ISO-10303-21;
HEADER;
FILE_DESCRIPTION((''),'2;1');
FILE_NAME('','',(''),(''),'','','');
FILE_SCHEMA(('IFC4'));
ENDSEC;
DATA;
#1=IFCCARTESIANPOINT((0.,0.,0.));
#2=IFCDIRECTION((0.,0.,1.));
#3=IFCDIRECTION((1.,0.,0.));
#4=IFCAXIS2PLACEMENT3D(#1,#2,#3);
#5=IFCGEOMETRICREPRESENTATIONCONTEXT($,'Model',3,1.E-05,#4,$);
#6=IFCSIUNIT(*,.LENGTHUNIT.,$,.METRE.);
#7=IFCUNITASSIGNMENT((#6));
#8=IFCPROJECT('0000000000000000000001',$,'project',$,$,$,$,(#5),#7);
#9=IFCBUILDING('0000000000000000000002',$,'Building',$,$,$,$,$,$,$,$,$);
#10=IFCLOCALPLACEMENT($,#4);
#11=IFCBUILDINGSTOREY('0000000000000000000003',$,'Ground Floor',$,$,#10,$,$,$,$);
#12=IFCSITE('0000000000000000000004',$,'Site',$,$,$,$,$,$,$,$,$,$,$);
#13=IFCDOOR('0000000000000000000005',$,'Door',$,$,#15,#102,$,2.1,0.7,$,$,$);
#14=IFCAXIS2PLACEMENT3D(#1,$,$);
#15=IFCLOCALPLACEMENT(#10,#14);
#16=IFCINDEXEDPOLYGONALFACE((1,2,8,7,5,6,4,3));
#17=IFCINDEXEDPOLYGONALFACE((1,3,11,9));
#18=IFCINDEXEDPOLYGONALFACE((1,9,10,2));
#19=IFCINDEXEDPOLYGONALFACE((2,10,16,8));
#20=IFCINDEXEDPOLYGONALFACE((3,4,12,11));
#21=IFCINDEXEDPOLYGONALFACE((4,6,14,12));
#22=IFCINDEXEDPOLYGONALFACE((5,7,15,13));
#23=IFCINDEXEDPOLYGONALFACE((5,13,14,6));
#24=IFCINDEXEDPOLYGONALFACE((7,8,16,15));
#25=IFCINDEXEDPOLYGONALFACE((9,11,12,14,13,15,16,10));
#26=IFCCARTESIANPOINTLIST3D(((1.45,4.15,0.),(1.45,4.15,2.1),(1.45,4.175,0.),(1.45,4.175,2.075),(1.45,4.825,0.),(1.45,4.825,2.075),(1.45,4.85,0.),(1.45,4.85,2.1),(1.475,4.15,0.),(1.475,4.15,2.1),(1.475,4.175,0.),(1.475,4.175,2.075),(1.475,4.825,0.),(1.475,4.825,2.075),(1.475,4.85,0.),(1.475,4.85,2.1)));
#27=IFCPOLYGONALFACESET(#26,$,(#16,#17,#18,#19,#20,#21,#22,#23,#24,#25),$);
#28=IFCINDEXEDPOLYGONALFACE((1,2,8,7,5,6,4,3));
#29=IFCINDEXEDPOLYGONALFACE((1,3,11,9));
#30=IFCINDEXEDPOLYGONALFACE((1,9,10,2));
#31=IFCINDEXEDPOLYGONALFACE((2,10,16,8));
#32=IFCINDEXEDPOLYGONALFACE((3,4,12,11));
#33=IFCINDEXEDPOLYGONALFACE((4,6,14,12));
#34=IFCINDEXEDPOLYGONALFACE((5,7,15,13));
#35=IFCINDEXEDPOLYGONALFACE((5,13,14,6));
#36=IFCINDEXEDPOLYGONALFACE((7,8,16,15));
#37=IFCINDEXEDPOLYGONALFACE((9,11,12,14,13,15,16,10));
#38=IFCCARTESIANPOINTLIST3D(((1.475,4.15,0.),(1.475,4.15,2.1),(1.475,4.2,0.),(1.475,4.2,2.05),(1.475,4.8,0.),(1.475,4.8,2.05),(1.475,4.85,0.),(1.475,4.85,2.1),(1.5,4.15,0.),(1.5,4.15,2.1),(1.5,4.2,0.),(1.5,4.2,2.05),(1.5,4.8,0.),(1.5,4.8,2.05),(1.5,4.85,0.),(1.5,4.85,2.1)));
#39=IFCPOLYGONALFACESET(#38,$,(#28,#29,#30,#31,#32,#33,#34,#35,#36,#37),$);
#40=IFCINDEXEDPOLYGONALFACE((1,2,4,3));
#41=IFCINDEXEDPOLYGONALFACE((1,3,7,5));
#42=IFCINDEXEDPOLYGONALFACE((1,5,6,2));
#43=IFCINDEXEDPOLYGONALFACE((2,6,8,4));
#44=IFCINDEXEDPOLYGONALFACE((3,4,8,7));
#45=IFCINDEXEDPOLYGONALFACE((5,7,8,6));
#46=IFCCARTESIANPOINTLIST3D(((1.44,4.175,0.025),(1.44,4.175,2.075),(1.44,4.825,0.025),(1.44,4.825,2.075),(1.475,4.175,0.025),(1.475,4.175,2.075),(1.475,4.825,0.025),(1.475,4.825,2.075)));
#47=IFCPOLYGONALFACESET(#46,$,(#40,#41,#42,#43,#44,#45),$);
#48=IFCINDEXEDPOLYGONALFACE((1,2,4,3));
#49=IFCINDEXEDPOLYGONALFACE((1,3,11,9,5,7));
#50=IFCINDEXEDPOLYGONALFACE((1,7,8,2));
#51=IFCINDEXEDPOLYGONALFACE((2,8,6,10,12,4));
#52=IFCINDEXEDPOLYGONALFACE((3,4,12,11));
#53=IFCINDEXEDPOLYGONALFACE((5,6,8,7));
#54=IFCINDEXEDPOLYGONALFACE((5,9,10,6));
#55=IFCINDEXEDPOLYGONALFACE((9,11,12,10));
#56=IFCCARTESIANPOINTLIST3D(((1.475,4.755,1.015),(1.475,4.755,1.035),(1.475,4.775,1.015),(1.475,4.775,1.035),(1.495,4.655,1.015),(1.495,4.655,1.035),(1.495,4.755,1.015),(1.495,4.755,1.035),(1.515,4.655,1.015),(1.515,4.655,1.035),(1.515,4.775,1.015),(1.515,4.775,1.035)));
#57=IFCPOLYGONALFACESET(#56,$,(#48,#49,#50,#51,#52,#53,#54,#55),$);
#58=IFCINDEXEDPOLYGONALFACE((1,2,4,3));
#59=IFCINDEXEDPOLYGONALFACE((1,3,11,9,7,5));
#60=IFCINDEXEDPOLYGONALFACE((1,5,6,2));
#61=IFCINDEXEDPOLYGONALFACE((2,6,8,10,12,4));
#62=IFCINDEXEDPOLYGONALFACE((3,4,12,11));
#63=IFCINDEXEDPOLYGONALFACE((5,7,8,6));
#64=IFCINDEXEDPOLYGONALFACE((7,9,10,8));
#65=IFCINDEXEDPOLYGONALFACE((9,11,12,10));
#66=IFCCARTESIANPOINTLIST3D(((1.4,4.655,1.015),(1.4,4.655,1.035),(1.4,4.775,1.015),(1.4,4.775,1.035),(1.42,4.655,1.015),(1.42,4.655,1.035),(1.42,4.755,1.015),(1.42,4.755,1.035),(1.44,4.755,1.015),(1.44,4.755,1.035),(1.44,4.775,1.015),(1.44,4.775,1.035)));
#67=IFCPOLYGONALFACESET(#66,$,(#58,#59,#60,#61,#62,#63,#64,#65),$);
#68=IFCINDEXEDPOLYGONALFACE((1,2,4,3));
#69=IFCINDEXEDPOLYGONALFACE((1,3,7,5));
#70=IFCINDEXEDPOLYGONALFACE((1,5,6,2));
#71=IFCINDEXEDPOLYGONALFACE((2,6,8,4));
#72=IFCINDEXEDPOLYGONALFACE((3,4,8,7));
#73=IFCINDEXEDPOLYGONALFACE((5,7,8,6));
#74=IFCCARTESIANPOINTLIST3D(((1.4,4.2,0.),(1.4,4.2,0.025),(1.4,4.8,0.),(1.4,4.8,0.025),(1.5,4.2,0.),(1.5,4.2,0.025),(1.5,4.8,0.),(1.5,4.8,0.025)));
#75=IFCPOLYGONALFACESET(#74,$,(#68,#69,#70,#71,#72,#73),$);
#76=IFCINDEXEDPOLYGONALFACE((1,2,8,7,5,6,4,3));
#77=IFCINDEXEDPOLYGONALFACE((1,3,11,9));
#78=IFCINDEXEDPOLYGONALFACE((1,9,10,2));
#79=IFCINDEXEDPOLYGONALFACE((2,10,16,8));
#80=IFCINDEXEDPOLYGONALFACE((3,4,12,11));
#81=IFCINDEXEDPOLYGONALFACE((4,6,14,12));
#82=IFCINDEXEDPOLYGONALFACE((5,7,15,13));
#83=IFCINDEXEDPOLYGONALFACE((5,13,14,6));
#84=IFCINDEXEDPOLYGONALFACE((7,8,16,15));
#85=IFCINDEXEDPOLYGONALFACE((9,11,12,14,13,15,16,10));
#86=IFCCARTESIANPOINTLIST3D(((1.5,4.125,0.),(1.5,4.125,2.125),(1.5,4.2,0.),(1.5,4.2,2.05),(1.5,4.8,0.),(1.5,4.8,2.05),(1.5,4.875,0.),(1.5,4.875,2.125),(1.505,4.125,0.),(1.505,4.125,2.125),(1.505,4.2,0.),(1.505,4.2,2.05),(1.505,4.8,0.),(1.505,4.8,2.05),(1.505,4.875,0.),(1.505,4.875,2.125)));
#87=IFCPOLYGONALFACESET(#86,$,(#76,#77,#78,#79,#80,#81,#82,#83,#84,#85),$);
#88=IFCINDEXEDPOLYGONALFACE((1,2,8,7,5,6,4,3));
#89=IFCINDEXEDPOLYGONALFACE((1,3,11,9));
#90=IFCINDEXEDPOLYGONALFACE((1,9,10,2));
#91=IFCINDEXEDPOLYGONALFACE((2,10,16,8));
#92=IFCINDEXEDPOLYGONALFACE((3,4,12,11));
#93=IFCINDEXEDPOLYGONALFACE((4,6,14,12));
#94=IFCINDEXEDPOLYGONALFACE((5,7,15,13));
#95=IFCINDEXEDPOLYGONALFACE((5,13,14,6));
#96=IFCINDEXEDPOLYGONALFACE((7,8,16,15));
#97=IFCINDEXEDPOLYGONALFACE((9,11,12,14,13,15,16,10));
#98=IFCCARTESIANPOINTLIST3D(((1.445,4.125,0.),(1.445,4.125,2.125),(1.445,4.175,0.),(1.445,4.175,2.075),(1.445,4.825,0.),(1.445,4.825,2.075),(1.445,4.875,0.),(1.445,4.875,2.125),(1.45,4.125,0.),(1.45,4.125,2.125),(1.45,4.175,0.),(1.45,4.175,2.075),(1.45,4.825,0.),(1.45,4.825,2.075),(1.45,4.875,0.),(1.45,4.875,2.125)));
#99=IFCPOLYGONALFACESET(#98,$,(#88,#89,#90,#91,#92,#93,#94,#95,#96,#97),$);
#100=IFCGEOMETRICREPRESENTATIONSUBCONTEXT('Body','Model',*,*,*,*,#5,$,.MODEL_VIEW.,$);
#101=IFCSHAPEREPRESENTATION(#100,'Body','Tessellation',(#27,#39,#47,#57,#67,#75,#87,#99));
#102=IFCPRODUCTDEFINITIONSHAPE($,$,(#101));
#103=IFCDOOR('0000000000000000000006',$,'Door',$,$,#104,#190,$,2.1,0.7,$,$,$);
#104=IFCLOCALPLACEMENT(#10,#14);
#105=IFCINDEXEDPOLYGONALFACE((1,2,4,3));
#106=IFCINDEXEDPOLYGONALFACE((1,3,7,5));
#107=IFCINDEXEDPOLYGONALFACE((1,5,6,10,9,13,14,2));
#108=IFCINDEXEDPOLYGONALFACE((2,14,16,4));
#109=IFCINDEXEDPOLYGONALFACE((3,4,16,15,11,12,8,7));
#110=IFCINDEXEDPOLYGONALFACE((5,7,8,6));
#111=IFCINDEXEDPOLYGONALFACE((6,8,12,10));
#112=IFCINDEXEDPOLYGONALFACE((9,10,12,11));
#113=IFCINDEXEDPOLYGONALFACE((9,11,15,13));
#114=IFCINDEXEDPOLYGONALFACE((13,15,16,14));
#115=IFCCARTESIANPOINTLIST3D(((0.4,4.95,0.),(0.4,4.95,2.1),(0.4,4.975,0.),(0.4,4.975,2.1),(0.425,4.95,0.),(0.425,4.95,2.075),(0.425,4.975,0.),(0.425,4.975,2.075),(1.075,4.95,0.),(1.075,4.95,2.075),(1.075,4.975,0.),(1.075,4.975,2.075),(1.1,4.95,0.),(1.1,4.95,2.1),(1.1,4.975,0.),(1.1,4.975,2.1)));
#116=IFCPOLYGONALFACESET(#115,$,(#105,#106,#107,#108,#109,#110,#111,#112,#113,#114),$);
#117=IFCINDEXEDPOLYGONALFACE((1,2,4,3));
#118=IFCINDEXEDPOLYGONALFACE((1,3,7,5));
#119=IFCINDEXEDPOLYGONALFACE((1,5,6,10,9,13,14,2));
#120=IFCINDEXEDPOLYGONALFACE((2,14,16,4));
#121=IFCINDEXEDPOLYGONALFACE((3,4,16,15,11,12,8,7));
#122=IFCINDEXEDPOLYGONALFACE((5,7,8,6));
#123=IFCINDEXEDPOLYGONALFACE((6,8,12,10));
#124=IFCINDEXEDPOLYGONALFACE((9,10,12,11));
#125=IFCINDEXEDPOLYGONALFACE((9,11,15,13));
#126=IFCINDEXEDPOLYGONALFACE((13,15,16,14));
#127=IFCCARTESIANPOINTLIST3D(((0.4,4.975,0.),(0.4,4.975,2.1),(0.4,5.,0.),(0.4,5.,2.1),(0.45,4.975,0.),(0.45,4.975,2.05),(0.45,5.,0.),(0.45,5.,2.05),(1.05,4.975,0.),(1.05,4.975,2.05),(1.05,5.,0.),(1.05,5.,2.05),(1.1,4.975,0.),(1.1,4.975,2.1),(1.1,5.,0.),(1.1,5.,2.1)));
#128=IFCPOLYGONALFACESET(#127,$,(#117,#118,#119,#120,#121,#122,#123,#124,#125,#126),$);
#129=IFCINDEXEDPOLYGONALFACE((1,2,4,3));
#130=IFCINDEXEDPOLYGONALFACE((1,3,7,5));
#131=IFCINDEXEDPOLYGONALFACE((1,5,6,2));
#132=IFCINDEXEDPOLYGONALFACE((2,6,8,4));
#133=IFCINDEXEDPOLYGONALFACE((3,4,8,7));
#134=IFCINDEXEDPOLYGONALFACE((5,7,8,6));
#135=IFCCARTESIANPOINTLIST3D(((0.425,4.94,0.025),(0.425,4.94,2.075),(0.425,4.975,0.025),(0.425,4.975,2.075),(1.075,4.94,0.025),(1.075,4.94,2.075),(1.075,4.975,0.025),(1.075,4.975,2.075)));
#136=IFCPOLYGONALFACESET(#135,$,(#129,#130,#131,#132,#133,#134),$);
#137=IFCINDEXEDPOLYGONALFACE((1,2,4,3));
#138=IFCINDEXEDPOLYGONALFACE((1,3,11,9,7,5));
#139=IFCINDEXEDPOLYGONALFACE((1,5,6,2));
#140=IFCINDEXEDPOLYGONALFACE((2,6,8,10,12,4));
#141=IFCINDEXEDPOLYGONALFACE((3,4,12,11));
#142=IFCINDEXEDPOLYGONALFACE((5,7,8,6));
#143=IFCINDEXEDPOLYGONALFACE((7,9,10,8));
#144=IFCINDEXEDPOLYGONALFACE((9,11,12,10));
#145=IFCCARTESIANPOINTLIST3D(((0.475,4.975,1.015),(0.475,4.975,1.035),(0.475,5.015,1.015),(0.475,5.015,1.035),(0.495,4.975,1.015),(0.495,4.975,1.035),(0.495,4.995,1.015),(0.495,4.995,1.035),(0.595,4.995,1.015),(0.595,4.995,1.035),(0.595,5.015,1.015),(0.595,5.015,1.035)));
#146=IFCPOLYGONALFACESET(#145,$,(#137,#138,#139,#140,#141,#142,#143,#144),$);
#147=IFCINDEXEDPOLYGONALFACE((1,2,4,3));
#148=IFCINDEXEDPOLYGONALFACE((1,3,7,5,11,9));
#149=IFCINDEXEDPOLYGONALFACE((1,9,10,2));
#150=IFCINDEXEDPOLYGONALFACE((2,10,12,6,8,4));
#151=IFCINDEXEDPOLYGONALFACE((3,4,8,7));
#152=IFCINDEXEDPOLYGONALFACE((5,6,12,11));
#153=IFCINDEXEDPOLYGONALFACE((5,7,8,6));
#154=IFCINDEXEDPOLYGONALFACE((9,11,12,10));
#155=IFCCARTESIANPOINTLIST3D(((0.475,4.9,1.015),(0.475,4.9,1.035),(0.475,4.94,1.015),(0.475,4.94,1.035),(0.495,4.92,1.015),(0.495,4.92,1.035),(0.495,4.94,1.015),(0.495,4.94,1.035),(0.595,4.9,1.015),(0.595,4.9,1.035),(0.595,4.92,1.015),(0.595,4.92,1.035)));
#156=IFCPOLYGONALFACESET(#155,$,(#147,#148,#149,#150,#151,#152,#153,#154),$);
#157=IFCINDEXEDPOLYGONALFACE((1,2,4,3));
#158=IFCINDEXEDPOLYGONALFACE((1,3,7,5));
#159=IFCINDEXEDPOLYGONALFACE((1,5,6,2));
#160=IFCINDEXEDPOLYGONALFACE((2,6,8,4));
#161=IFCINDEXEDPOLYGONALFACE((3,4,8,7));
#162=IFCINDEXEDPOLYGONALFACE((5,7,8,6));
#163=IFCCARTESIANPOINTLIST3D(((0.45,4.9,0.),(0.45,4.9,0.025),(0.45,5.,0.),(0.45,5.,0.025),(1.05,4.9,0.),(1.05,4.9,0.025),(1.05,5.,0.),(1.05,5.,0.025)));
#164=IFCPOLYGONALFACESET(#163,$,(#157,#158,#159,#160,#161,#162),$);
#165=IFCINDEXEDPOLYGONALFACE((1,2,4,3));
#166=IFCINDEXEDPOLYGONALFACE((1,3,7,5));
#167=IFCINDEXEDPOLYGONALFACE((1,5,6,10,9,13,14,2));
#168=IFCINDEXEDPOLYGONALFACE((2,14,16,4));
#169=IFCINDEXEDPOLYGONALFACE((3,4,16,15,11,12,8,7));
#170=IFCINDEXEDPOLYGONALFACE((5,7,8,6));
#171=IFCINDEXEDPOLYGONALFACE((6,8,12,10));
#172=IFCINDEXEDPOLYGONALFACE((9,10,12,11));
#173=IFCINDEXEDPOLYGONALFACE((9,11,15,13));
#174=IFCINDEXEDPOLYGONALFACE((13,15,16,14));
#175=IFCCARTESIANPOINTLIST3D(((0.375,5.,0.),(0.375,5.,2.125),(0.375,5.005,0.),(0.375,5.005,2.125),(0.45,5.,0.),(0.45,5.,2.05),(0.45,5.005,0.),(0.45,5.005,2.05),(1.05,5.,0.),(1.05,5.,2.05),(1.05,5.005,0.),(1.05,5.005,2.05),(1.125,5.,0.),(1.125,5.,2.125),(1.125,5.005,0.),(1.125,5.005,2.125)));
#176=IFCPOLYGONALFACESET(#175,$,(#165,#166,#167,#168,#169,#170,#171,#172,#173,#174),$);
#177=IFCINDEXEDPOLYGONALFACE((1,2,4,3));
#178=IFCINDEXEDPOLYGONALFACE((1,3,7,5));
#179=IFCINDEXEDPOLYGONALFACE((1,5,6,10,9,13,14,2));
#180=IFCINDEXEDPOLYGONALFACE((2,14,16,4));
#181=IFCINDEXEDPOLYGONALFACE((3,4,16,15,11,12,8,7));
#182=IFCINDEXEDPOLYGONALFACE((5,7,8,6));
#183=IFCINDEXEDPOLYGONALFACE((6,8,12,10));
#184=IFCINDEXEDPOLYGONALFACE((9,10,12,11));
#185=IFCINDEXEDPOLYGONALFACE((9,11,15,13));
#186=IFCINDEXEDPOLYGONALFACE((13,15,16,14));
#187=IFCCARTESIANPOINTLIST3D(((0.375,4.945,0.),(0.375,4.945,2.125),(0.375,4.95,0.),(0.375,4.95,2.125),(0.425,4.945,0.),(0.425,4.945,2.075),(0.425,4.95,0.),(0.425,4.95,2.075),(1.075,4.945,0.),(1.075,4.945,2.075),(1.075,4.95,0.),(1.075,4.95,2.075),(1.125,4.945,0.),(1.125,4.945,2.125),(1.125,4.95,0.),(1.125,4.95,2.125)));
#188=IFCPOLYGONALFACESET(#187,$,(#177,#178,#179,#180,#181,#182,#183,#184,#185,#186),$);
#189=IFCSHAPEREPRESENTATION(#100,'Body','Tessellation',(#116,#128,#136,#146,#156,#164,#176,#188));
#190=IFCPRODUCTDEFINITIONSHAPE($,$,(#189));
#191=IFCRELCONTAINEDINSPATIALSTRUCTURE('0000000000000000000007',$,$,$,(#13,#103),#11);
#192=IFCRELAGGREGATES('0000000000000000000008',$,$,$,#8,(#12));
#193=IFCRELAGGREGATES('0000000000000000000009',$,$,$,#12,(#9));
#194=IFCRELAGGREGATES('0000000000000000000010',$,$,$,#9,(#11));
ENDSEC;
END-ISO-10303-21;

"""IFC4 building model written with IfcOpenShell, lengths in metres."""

from ifc_helpers import new_model, si_unit, frame, origin_with_axes, place, context, subcontext, project, spatial, line, indexed_curve, outline, extrude, element, save


model = new_model("IFC4")

# Units and contexts
model_context = context("Model", 3, precision=1e-05, world=origin_with_axes())
body_context = subcontext(model_context, "Body", "Model", "MODEL_VIEW")
ifc_project = project(units=[si_unit("LENGTHUNIT", "METRE")], contexts=[model_context])

# Site, building, storey
site = spatial("IfcSite", under=ifc_project, Name="Site")
building = spatial("IfcBuilding", under=site, Name="Building")
storey_placement = place(None, origin_with_axes())
storey = spatial("IfcBuildingStorey", under=building, at=storey_placement, Name="Ground Floor")

# Doors
door_1_placement = place(storey_placement, frame((1.5, 4.15, 0.0), z_axis=(0.0, 0.0, 1.0), x_axis=(0.0, 1.0, 0.0)))
element("IfcDoor", 1, at=door_1_placement, inside=storey, Name="Door", OverallHeight=2.1, OverallWidth=0.7, context=body_context, shape_type="SweptSolid", body=[
    extrude(outline(indexed_curve([(0.0, 0.0), (0.0, 2.1), (0.7, 2.1), (0.7, 0.0), (0.675, 0.0), (0.675, 2.075), (0.025, 2.075), (0.025, 0.0)], segments=[line(1, 2, 3, 4, 5, 6, 7, 8, 1)])), frame((0.0, 0.025, 0.0), z_axis=(0.0, -1.0, 0.0), x_axis=(1.0, 0.0, 0.0)), (0.0, 0.0, -1.0), 0.025),
    extrude(outline(indexed_curve([(0.0, 0.0), (0.0, 2.1), (0.7, 2.1), (0.7, 0.0), (0.65, 0.0), (0.65, 2.05), (0.05, 2.05), (0.05, 0.0)], segments=[line(1, 2, 3, 4, 5, 6, 7, 8, 1)])), frame((0.0, 0.0, 0.0), z_axis=(0.0, -1.0, 0.0), x_axis=(1.0, 0.0, 0.0)), (0.0, 0.0, -1.0), 0.025),
    extrude(outline(indexed_curve([(0.0, 0.0), (0.65, 0.0), (0.65, 0.035), (0.0, 0.035)], segments=[line(1, 2, 3, 4, 1)])), frame((0.025, 0.025, 0.025), z_axis=(0.0, 0.0, 1.0), x_axis=(1.0, 0.0, 0.0)), (0.0, 0.0, 1.0), 2.05),
    extrude(outline(indexed_curve([(0.0, 0.0), (0.0, -0.04), (-0.12, -0.04), (-0.12, -0.02), (-0.02, -0.02), (-0.02, 0.0)], segments=[line(1, 2, 3, 4, 5, 6, 1)])), frame((0.625, 0.025, 1.015), z_axis=(0.0, 0.0, 1.0), x_axis=(1.0, 0.0, 0.0)), (0.0, 0.0, 1.0), 0.02),
    extrude(outline(indexed_curve([(0.0, 0.0), (0.0, 0.04), (-0.12, 0.04), (-0.12, 0.02), (-0.02, 0.02), (-0.02, 0.0)], segments=[line(1, 2, 3, 4, 5, 6, 1)])), frame((0.625, 0.06, 1.015), z_axis=(0.0, 0.0, 1.0), x_axis=(1.0, 0.0, 0.0)), (0.0, 0.0, 1.0), 0.02),
    extrude(outline(indexed_curve([(0.0, 0.0), (0.6, 0.0), (0.6, 0.1), (0.0, 0.1)], segments=[line(1, 2, 3, 4, 1)])), frame((0.05, 0.0, 0.0), z_axis=(0.0, 0.0, 1.0), x_axis=(1.0, 0.0, 0.0)), (0.0, 0.0, 1.0), 0.025),
    extrude(outline(indexed_curve([(0.0, 0.0), (0.0, 2.125), (0.75, 2.125), (0.75, 0.0), (0.675, 0.0), (0.675, 2.05), (0.075, 2.05), (0.075, 0.0)], segments=[line(1, 2, 3, 4, 5, 6, 7, 8, 1)])), frame((-0.025, -0.005, 0.0), z_axis=(0.0, -1.0, 0.0), x_axis=(1.0, 0.0, 0.0)), (0.0, 0.0, -1.0), 0.005),
    extrude(outline(indexed_curve([(0.0, 0.0), (0.0, 2.125), (0.75, 2.125), (0.75, 0.0), (0.7, 0.0), (0.7, 2.075), (0.05, 2.075), (0.05, 0.0)], segments=[line(1, 2, 3, 4, 5, 6, 7, 8, 1)])), frame((-0.025, 0.05, 0.0), z_axis=(0.0, -1.0, 0.0), x_axis=(1.0, 0.0, 0.0)), (0.0, 0.0, -1.0), 0.005),
])
door_2_placement = place(storey_placement, frame((1.1, 5.0, 0.0), z_axis=(0.0, 0.0, 1.0), x_axis=(-1.0, 0.0, 0.0)))
element("IfcDoor", 2, at=door_2_placement, inside=storey, Name="Door", OverallHeight=2.1, OverallWidth=0.7, context=body_context, shape_type="SweptSolid", body=[
    extrude(outline(indexed_curve([(0.0, 0.0), (0.0, 2.1), (0.7, 2.1), (0.7, 0.0), (0.675, 0.0), (0.675, 2.075), (0.025, 2.075), (0.025, 0.0)], segments=[line(1, 2, 3, 4, 5, 6, 7, 8, 1)])), frame((0.0, 0.025, 0.0), z_axis=(0.0, -1.0, 0.0), x_axis=(1.0, 0.0, 0.0)), (0.0, 0.0, -1.0), 0.025),
    extrude(outline(indexed_curve([(0.0, 0.0), (0.0, 2.1), (0.7, 2.1), (0.7, 0.0), (0.65, 0.0), (0.65, 2.05), (0.05, 2.05), (0.05, 0.0)], segments=[line(1, 2, 3, 4, 5, 6, 7, 8, 1)])), frame((0.0, 0.0, 0.0), z_axis=(0.0, -1.0, 0.0), x_axis=(1.0, 0.0, 0.0)), (0.0, 0.0, -1.0), 0.025),
    extrude(outline(indexed_curve([(0.0, 0.0), (0.65, 0.0), (0.65, 0.035), (0.0, 0.035)], segments=[line(1, 2, 3, 4, 1)])), frame((0.025, 0.025, 0.025), z_axis=(0.0, 0.0, 1.0), x_axis=(1.0, 0.0, 0.0)), (0.0, 0.0, 1.0), 2.05),
    extrude(outline(indexed_curve([(0.0, 0.0), (0.0, -0.04), (-0.12, -0.04), (-0.12, -0.02), (-0.02, -0.02), (-0.02, 0.0)], segments=[line(1, 2, 3, 4, 5, 6, 1)])), frame((0.625, 0.025, 1.015), z_axis=(0.0, 0.0, 1.0), x_axis=(1.0, 0.0, 0.0)), (0.0, 0.0, 1.0), 0.02),
    extrude(outline(indexed_curve([(0.0, 0.0), (0.0, 0.04), (-0.12, 0.04), (-0.12, 0.02), (-0.02, 0.02), (-0.02, 0.0)], segments=[line(1, 2, 3, 4, 5, 6, 1)])), frame((0.625, 0.06, 1.015), z_axis=(0.0, 0.0, 1.0), x_axis=(1.0, 0.0, 0.0)), (0.0, 0.0, 1.0), 0.02),
    extrude(outline(indexed_curve([(0.0, 0.0), (0.6, 0.0), (0.6, 0.1), (0.0, 0.1)], segments=[line(1, 2, 3, 4, 1)])), frame((0.05, 0.0, 0.0), z_axis=(0.0, 0.0, 1.0), x_axis=(1.0, 0.0, 0.0)), (0.0, 0.0, 1.0), 0.025),
    extrude(outline(indexed_curve([(0.0, 0.0), (0.0, 2.125), (0.75, 2.125), (0.75, 0.0), (0.675, 0.0), (0.675, 2.05), (0.075, 2.05), (0.075, 0.0)], segments=[line(1, 2, 3, 4, 5, 6, 7, 8, 1)])), frame((-0.025, -0.005, 0.0), z_axis=(0.0, -1.0, 0.0), x_axis=(1.0, 0.0, 0.0)), (0.0, 0.0, -1.0), 0.005),
    extrude(outline(indexed_curve([(0.0, 0.0), (0.0, 2.125), (0.75, 2.125), (0.75, 0.0), (0.7, 0.0), (0.7, 2.075), (0.05, 2.075), (0.05, 0.0)], segments=[line(1, 2, 3, 4, 5, 6, 7, 8, 1)])), frame((-0.025, 0.05, 0.0), z_axis=(0.0, -1.0, 0.0), x_axis=(1.0, 0.0, 0.0)), (0.0, 0.0, -1.0), 0.005),
])

save(model, "model.ifc")
